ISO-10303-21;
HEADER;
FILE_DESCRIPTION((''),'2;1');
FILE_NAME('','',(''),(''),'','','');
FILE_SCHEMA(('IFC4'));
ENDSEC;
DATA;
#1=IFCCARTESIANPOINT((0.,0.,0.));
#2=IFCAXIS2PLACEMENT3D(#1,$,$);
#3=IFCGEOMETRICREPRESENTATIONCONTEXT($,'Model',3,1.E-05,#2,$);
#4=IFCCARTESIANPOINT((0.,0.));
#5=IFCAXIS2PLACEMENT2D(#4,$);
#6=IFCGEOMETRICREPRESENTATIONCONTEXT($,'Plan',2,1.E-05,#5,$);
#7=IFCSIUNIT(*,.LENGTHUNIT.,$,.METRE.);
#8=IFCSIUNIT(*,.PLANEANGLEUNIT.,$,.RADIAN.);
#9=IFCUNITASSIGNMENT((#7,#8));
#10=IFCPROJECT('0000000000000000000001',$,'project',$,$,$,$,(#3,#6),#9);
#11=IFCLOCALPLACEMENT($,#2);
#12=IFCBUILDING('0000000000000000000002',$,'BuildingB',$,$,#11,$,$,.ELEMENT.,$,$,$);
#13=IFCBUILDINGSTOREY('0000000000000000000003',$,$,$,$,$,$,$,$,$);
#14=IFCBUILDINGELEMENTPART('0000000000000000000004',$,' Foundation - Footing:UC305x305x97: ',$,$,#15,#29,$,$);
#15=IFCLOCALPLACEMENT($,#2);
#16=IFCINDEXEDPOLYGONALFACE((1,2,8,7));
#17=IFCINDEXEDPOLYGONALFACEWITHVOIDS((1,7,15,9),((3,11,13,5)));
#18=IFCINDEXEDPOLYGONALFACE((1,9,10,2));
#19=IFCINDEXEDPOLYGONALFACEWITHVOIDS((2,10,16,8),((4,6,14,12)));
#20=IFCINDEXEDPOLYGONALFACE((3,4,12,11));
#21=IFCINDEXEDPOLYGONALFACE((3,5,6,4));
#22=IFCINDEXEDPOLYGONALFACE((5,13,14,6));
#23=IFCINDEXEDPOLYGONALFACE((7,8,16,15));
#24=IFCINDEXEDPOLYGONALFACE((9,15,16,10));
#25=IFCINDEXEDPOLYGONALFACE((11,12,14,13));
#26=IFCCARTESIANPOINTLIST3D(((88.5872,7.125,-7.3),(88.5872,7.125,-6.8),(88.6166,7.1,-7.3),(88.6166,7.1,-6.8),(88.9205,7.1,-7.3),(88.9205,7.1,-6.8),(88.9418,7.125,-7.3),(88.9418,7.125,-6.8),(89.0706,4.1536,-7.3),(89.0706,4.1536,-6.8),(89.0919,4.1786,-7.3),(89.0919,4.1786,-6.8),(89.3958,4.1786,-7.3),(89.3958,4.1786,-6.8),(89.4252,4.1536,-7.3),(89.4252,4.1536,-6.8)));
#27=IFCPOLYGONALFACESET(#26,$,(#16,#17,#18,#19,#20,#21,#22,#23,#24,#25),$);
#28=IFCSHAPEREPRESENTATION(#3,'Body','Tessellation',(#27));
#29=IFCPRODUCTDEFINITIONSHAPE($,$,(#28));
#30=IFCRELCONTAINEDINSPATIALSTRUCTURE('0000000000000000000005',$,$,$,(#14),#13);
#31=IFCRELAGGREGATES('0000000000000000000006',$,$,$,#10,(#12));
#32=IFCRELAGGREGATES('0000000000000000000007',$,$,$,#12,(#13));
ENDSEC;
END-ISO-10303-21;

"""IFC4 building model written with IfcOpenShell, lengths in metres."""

from ifc_helpers import new_model, si_unit, origin, origin_2d, place, context, project, spatial, polyline, outline, extrude, element, save


model = new_model("IFC4")

# Units and contexts
model_context = context("Model", 3, precision=1e-05, world=origin())
plan_context = context("Plan", 2, precision=1e-05, world=origin_2d())
ifc_project = project(units=[si_unit("LENGTHUNIT", "METRE"), si_unit("PLANEANGLEUNIT", "RADIAN")], contexts=[model_context, plan_context])

# Building, storey
building_placement = place(None, origin())
building = spatial("IfcBuilding", under=ifc_project, at=building_placement, Name="BuildingB", CompositionType="ELEMENT")
storey = spatial("IfcBuildingStorey", under=building)

# Building element part, opening
building_element_part_1 = element("IfcBuildingElementPart", 1, inside=storey, Name=" Foundation - Footing:UC305x305x97: ", context=model_context, shape_type="SweptSolid", body=[
    extrude(outline(polyline([(89.4252, 4.1536, -7.3), (89.0706, 4.1536, -7.3), (88.5872, 7.125, -7.3), (88.9418, 7.125, -7.3), (89.4252, 4.1536, -7.3)])), None, (0.0, 0.0, 1.0), 0.5),
])
element("IfcOpeningElement", 2, inside=storey, cuts=building_element_part_1, context=model_context, shape_type="SweptSolid", body=[
    extrude(outline(polyline([(89.3958, 4.1786, -7.3), (89.0919, 4.1786, -7.3), (88.6166, 7.1, -7.3), (88.9205, 7.1, -7.3), (89.3958, 4.1786, -7.3)])), None, (0.0, 0.0, 1.0), 0.5),
])

save(model, "model.ifc")
